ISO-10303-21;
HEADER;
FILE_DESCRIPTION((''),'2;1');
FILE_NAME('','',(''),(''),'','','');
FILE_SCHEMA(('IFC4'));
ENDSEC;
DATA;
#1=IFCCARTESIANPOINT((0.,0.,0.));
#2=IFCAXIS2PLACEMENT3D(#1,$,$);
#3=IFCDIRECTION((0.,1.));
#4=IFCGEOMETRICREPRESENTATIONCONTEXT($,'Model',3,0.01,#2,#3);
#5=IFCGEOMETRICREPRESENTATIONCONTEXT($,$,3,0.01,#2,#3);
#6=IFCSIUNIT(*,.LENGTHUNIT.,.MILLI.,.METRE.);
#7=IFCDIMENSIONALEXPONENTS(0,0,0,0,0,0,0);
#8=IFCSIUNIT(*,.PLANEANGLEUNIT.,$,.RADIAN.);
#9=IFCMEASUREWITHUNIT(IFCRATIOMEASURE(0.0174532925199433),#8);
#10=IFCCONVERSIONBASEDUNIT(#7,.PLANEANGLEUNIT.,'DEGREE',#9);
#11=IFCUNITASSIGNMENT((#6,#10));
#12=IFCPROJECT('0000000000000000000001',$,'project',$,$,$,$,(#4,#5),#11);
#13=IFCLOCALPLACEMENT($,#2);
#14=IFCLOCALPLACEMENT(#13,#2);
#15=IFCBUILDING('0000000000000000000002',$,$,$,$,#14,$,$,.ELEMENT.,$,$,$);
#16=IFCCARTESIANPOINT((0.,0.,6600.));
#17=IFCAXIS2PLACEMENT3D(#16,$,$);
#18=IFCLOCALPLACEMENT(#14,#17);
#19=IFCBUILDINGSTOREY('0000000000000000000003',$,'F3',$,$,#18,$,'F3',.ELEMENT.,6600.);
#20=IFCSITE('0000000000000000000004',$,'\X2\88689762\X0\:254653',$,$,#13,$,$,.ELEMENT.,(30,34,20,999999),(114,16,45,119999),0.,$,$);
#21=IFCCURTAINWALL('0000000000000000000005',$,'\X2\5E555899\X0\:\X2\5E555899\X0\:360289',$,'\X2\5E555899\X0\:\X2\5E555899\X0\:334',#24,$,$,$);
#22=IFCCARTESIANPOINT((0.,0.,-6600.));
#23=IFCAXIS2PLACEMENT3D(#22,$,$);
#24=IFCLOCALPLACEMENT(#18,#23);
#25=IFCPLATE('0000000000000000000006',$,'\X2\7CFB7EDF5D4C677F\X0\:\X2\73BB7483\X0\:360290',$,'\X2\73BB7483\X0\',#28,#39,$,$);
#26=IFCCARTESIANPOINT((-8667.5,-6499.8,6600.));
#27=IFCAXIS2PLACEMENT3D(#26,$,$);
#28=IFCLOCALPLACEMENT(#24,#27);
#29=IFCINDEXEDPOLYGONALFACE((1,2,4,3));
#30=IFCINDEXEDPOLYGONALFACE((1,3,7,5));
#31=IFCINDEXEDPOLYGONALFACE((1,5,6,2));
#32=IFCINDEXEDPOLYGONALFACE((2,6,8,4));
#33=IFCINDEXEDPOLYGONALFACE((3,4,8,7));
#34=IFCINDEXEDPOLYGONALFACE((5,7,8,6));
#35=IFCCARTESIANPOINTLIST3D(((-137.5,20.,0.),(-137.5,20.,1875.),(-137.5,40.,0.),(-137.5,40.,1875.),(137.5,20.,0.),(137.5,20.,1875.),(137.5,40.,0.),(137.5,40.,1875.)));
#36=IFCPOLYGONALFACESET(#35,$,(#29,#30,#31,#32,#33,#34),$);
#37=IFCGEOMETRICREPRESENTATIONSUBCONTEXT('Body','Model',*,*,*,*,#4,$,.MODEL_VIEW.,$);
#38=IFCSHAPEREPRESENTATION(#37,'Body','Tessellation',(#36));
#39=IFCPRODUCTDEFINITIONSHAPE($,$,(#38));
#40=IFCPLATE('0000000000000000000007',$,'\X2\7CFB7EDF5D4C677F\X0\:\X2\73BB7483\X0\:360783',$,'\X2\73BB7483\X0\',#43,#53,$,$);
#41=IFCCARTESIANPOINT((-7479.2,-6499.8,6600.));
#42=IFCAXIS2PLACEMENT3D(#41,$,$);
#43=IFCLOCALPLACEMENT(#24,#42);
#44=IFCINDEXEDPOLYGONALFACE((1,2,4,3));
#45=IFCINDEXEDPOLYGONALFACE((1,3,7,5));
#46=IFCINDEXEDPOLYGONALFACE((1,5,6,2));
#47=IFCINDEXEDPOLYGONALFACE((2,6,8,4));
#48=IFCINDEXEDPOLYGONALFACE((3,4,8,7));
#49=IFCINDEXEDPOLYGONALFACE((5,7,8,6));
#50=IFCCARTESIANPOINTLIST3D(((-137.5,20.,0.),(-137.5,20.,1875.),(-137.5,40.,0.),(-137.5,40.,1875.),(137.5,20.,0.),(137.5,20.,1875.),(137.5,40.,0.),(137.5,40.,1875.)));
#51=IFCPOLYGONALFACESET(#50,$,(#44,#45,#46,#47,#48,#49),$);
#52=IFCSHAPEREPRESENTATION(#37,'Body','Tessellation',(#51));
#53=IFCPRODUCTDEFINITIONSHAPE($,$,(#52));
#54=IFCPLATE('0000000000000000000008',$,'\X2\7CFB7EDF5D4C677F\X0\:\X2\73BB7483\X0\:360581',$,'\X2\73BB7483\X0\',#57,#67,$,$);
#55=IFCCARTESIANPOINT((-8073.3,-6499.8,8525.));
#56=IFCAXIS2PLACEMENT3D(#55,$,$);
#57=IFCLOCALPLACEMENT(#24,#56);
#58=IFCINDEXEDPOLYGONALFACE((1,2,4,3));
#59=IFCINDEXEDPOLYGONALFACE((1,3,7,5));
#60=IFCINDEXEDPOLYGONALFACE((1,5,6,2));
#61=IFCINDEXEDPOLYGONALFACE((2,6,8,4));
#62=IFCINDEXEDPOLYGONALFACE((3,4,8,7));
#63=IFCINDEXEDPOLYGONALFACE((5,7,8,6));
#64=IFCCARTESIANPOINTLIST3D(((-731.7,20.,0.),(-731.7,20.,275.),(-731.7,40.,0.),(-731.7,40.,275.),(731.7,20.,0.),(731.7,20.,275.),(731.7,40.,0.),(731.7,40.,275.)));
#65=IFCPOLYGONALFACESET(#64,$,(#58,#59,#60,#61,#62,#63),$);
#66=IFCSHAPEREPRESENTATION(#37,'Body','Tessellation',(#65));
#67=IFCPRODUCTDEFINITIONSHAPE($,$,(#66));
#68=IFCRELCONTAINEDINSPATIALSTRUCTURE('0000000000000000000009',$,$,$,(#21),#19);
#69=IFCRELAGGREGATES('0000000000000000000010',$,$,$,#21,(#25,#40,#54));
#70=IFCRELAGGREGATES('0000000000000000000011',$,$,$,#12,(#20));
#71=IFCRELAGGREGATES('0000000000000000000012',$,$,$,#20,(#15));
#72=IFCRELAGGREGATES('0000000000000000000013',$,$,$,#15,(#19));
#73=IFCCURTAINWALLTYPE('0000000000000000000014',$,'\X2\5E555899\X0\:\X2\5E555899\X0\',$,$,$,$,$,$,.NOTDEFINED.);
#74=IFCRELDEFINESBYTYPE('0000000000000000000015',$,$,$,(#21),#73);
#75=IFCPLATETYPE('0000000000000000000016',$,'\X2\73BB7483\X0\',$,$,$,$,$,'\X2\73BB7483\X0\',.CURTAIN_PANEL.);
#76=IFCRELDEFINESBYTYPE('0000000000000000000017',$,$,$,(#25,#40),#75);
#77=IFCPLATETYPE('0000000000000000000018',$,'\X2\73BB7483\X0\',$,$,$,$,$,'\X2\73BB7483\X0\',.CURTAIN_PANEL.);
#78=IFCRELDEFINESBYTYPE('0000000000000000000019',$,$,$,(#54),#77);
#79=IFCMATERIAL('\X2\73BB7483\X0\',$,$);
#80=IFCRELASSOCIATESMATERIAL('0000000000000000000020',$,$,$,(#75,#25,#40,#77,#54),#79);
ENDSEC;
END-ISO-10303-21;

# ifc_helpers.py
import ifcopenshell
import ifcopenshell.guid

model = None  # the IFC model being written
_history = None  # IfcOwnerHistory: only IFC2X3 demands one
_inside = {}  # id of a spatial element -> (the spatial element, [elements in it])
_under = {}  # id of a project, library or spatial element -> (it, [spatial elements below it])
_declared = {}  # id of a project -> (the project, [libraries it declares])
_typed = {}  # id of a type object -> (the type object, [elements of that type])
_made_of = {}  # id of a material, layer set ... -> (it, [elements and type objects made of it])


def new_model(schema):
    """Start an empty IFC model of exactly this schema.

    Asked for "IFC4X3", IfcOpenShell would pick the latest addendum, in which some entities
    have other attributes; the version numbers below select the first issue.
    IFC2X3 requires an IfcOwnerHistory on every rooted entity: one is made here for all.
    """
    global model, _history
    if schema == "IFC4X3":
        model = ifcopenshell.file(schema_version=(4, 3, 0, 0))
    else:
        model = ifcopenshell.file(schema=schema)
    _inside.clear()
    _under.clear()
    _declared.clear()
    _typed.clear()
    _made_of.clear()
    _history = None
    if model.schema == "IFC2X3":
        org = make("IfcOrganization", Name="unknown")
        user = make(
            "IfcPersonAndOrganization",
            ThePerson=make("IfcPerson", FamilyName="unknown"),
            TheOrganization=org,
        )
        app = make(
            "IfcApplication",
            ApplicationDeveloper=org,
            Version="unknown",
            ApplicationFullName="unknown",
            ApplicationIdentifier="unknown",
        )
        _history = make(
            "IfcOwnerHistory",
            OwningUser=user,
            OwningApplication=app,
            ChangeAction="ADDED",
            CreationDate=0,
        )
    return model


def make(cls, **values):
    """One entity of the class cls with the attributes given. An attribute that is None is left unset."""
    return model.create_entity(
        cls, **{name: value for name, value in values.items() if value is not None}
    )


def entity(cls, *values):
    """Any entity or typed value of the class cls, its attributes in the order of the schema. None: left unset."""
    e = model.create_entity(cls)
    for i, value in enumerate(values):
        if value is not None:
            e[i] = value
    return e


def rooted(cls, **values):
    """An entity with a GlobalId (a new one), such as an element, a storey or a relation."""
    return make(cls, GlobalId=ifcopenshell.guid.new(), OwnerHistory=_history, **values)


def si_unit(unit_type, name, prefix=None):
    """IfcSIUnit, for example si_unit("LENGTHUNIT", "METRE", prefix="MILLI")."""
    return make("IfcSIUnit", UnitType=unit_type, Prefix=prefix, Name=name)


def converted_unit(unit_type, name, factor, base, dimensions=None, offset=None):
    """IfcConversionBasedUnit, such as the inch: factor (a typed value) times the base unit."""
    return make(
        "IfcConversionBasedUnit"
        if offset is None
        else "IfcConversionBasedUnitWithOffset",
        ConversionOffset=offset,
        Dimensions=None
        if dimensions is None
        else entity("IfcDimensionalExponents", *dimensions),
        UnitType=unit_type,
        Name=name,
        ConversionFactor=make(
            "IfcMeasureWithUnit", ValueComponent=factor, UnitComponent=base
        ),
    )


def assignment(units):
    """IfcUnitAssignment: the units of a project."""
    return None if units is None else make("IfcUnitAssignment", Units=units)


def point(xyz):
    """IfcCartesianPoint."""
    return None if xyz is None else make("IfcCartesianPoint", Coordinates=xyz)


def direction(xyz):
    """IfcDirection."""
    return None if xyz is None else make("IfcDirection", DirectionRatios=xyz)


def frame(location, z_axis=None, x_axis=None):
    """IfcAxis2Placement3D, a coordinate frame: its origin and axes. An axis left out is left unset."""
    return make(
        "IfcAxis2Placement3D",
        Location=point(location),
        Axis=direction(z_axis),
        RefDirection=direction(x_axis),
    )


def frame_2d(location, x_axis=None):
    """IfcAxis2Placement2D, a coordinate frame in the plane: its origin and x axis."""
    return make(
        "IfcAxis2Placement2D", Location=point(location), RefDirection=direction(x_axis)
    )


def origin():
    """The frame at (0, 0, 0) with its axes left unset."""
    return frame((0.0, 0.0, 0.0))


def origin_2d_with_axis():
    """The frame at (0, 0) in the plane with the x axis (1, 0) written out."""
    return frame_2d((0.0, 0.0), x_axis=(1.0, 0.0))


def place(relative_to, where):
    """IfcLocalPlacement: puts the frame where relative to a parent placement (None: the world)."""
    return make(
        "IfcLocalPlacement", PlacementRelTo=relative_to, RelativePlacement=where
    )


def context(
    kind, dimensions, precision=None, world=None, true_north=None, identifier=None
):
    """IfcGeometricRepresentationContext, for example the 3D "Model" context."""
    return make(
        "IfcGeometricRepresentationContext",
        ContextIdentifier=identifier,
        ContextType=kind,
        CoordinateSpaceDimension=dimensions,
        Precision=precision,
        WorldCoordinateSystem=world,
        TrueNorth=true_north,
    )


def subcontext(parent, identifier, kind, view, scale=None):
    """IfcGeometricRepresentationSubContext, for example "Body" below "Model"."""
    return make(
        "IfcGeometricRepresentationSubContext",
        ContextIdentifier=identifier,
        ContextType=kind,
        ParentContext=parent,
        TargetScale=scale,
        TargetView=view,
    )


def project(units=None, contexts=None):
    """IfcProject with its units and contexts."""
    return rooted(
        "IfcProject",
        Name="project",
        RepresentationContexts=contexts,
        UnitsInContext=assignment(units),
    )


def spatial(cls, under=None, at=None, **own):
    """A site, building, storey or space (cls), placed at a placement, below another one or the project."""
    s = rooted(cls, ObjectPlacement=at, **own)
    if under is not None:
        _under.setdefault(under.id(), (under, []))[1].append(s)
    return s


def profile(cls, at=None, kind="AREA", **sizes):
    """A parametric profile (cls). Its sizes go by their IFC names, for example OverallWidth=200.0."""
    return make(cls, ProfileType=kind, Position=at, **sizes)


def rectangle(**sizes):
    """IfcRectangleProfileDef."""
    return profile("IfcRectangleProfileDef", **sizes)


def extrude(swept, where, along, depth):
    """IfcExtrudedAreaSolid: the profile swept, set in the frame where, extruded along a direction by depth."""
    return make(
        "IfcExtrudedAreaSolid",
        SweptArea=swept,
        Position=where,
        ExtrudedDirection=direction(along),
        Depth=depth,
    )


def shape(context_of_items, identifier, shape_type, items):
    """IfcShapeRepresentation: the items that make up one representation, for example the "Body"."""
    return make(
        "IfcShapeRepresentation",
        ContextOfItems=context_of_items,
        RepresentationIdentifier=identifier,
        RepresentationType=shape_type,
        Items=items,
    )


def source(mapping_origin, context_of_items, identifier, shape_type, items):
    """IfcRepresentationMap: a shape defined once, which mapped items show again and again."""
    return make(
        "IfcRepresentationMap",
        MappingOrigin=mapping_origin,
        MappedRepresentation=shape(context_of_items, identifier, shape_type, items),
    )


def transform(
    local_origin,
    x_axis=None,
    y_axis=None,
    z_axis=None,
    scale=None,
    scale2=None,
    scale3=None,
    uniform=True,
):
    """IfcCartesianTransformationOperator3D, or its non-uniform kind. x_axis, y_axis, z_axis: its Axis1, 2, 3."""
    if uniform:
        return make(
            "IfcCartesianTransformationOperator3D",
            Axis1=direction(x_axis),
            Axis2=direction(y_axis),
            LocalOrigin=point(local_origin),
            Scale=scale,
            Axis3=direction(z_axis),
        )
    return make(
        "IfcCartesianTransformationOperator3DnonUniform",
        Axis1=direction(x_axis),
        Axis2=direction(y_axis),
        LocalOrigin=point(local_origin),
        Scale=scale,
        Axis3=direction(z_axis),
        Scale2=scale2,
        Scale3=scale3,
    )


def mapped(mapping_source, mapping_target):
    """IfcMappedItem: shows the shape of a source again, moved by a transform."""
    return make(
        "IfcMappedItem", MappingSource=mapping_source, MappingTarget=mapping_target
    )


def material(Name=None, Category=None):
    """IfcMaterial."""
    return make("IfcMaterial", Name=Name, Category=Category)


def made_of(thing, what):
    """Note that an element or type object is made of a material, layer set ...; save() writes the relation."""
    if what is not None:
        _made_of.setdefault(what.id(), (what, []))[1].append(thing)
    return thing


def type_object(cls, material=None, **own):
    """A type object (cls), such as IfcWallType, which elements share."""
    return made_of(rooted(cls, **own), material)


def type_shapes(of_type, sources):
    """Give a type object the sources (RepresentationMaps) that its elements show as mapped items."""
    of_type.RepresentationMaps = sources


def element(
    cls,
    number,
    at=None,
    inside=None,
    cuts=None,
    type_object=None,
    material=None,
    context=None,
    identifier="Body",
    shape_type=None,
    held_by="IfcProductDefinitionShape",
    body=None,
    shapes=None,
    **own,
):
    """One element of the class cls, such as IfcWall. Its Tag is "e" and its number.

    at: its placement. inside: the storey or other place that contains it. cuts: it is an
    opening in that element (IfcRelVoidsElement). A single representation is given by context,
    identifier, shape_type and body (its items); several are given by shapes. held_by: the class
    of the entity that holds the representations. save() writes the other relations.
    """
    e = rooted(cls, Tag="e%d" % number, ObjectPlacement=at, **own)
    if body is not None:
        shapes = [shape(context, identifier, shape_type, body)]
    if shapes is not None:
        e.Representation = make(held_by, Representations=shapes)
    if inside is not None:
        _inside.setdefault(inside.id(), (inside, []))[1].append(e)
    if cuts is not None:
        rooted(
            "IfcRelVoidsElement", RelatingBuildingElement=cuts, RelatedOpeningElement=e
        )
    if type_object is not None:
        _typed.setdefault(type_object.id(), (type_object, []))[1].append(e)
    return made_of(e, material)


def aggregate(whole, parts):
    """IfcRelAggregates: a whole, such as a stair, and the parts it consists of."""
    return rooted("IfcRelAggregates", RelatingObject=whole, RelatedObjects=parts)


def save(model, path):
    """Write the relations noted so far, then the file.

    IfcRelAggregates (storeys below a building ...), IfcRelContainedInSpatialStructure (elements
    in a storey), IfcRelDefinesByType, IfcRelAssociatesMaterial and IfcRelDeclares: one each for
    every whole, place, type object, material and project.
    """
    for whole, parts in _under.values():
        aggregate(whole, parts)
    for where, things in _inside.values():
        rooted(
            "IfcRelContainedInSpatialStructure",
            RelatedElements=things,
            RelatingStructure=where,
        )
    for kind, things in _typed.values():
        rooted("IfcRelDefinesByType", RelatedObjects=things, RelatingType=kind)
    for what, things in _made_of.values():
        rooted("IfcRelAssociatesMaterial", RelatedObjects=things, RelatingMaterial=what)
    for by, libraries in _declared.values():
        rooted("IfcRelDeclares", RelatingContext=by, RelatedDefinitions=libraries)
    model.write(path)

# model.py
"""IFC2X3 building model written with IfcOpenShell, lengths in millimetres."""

from ifc_helpers import new_model, entity, si_unit, converted_unit, direction, frame, frame_2d, origin, origin_2d_with_axis, place, context, subcontext, project, spatial, rectangle, extrude, source, transform, mapped, material, type_object, type_shapes, element, aggregate, save


model = new_model("IFC2X3")

# Units and contexts
model_context = context("Model", 3, precision=0.01, world=origin(), true_north=direction((0.0, 1.0)))
context_of_model = context(None, 3, precision=0.01, world=origin(), true_north=direction((0.0, 1.0)))
body_context = subcontext(model_context, "Body", "Model", "MODEL_VIEW")
ifc_project = project(units=[si_unit("LENGTHUNIT", "METRE", prefix="MILLI"), converted_unit("PLANEANGLEUNIT", "DEGREE", entity("IfcRatioMeasure", 0.0174532925199433), si_unit("PLANEANGLEUNIT", "RADIAN"), dimensions=[0, 0, 0, 0, 0, 0, 0])], contexts=[model_context, context_of_model])

# Site, building, storey
site_placement = place(None, origin())
site = spatial("IfcSite", under=ifc_project, at=site_placement, Name="表面:254653", CompositionType="ELEMENT", RefLatitude=(30, 34, 20, 999999), RefLongitude=(114, 16, 45, 119999), RefElevation=0.0)
building_placement = place(site_placement, origin())
building = spatial("IfcBuilding", under=site, at=building_placement, CompositionType="ELEMENT")
storey_placement = place(building_placement, frame((0.0, 0.0, 6600.0)))
storey = spatial("IfcBuildingStorey", under=building, at=storey_placement, Name="F3", LongName="F3", CompositionType="ELEMENT", Elevation=6600.0)

# Shared definitions
ifc_material_1 = material(Name="玻璃")

# Curtain wall, plates
curtain_wall_type_1 = type_object("IfcCurtainWallType", Name="幕墙:幕墙", PredefinedType="NOTDEFINED")
curtain_wall_placement = place(storey_placement, frame((0.0, 0.0, -6600.0)))
curtain_wall = element("IfcCurtainWall", 1, at=curtain_wall_placement, inside=storey, type_object=curtain_wall_type_1, Name="幕墙:幕墙:360289", ObjectType="幕墙:幕墙:334")
plate_type_1 = type_object("IfcPlateType", Name="玻璃", ElementType="玻璃", PredefinedType="CURTAIN_PANEL", material=ifc_material_1)
shared_shape_1 = source(origin(), body_context, "Body", "SweptSolid", [
    extrude(rectangle(XDim=20.0, YDim=275.0, at=frame_2d((0.0, 0.0), x_axis=(1.0, 0.0))), frame((0.0, 30.0, 0.0), z_axis=(0.0, 0.0, 1.0), x_axis=(0.0, 1.0, 0.0)), (0.0, 0.0, 1.0), 1875.0),
])
type_shapes(plate_type_1, [shared_shape_1])
plate_1_placement = place(curtain_wall_placement, frame((-8667.5, -6499.8, 6600.0)))
plate_1 = element("IfcPlate", 2, at=plate_1_placement, type_object=plate_type_1, material=ifc_material_1, Name="系统嵌板:玻璃:360290", ObjectType="玻璃", context=body_context, shape_type="MappedRepresentation", body=[
    mapped(shared_shape_1, transform((0.0, 0.0, 0.0), scale=1.0)),
])
plate_2_placement = place(curtain_wall_placement, frame((-7479.2, -6499.8, 6600.0)))
plate_2 = element("IfcPlate", 3, at=plate_2_placement, type_object=plate_type_1, material=ifc_material_1, Name="系统嵌板:玻璃:360783", ObjectType="玻璃", context=body_context, shape_type="MappedRepresentation", body=[
    mapped(shared_shape_1, transform((0.0, 0.0, 0.0), scale=1.0)),
])
plate_type_2 = type_object("IfcPlateType", Name="玻璃", ElementType="玻璃", PredefinedType="CURTAIN_PANEL", material=ifc_material_1)
shared_shape_2 = source(origin(), body_context, "Body", "SweptSolid", [
    extrude(rectangle(XDim=275.0, YDim=1463.3, at=origin_2d_with_axis()), frame((0.0, 20.0, 137.5), z_axis=(0.0, 1.0, 0.0), x_axis=(0.0, 0.0, 1.0)), (0.0, 0.0, 1.0), 20.0),
])
type_shapes(plate_type_2, [shared_shape_2])
plate_3_placement = place(curtain_wall_placement, frame((-8073.3, -6499.8, 8525.0)))
plate_3 = element("IfcPlate", 4, at=plate_3_placement, type_object=plate_type_2, material=ifc_material_1, Name="系统嵌板:玻璃:360581", ObjectType="玻璃", context=body_context, shape_type="MappedRepresentation", body=[
    mapped(shared_shape_2, transform((0.0, 0.0, 0.0), scale=1.0)),
])

aggregate(curtain_wall, [plate_1, plate_2, plate_3])

save(model, "model.ifc")
